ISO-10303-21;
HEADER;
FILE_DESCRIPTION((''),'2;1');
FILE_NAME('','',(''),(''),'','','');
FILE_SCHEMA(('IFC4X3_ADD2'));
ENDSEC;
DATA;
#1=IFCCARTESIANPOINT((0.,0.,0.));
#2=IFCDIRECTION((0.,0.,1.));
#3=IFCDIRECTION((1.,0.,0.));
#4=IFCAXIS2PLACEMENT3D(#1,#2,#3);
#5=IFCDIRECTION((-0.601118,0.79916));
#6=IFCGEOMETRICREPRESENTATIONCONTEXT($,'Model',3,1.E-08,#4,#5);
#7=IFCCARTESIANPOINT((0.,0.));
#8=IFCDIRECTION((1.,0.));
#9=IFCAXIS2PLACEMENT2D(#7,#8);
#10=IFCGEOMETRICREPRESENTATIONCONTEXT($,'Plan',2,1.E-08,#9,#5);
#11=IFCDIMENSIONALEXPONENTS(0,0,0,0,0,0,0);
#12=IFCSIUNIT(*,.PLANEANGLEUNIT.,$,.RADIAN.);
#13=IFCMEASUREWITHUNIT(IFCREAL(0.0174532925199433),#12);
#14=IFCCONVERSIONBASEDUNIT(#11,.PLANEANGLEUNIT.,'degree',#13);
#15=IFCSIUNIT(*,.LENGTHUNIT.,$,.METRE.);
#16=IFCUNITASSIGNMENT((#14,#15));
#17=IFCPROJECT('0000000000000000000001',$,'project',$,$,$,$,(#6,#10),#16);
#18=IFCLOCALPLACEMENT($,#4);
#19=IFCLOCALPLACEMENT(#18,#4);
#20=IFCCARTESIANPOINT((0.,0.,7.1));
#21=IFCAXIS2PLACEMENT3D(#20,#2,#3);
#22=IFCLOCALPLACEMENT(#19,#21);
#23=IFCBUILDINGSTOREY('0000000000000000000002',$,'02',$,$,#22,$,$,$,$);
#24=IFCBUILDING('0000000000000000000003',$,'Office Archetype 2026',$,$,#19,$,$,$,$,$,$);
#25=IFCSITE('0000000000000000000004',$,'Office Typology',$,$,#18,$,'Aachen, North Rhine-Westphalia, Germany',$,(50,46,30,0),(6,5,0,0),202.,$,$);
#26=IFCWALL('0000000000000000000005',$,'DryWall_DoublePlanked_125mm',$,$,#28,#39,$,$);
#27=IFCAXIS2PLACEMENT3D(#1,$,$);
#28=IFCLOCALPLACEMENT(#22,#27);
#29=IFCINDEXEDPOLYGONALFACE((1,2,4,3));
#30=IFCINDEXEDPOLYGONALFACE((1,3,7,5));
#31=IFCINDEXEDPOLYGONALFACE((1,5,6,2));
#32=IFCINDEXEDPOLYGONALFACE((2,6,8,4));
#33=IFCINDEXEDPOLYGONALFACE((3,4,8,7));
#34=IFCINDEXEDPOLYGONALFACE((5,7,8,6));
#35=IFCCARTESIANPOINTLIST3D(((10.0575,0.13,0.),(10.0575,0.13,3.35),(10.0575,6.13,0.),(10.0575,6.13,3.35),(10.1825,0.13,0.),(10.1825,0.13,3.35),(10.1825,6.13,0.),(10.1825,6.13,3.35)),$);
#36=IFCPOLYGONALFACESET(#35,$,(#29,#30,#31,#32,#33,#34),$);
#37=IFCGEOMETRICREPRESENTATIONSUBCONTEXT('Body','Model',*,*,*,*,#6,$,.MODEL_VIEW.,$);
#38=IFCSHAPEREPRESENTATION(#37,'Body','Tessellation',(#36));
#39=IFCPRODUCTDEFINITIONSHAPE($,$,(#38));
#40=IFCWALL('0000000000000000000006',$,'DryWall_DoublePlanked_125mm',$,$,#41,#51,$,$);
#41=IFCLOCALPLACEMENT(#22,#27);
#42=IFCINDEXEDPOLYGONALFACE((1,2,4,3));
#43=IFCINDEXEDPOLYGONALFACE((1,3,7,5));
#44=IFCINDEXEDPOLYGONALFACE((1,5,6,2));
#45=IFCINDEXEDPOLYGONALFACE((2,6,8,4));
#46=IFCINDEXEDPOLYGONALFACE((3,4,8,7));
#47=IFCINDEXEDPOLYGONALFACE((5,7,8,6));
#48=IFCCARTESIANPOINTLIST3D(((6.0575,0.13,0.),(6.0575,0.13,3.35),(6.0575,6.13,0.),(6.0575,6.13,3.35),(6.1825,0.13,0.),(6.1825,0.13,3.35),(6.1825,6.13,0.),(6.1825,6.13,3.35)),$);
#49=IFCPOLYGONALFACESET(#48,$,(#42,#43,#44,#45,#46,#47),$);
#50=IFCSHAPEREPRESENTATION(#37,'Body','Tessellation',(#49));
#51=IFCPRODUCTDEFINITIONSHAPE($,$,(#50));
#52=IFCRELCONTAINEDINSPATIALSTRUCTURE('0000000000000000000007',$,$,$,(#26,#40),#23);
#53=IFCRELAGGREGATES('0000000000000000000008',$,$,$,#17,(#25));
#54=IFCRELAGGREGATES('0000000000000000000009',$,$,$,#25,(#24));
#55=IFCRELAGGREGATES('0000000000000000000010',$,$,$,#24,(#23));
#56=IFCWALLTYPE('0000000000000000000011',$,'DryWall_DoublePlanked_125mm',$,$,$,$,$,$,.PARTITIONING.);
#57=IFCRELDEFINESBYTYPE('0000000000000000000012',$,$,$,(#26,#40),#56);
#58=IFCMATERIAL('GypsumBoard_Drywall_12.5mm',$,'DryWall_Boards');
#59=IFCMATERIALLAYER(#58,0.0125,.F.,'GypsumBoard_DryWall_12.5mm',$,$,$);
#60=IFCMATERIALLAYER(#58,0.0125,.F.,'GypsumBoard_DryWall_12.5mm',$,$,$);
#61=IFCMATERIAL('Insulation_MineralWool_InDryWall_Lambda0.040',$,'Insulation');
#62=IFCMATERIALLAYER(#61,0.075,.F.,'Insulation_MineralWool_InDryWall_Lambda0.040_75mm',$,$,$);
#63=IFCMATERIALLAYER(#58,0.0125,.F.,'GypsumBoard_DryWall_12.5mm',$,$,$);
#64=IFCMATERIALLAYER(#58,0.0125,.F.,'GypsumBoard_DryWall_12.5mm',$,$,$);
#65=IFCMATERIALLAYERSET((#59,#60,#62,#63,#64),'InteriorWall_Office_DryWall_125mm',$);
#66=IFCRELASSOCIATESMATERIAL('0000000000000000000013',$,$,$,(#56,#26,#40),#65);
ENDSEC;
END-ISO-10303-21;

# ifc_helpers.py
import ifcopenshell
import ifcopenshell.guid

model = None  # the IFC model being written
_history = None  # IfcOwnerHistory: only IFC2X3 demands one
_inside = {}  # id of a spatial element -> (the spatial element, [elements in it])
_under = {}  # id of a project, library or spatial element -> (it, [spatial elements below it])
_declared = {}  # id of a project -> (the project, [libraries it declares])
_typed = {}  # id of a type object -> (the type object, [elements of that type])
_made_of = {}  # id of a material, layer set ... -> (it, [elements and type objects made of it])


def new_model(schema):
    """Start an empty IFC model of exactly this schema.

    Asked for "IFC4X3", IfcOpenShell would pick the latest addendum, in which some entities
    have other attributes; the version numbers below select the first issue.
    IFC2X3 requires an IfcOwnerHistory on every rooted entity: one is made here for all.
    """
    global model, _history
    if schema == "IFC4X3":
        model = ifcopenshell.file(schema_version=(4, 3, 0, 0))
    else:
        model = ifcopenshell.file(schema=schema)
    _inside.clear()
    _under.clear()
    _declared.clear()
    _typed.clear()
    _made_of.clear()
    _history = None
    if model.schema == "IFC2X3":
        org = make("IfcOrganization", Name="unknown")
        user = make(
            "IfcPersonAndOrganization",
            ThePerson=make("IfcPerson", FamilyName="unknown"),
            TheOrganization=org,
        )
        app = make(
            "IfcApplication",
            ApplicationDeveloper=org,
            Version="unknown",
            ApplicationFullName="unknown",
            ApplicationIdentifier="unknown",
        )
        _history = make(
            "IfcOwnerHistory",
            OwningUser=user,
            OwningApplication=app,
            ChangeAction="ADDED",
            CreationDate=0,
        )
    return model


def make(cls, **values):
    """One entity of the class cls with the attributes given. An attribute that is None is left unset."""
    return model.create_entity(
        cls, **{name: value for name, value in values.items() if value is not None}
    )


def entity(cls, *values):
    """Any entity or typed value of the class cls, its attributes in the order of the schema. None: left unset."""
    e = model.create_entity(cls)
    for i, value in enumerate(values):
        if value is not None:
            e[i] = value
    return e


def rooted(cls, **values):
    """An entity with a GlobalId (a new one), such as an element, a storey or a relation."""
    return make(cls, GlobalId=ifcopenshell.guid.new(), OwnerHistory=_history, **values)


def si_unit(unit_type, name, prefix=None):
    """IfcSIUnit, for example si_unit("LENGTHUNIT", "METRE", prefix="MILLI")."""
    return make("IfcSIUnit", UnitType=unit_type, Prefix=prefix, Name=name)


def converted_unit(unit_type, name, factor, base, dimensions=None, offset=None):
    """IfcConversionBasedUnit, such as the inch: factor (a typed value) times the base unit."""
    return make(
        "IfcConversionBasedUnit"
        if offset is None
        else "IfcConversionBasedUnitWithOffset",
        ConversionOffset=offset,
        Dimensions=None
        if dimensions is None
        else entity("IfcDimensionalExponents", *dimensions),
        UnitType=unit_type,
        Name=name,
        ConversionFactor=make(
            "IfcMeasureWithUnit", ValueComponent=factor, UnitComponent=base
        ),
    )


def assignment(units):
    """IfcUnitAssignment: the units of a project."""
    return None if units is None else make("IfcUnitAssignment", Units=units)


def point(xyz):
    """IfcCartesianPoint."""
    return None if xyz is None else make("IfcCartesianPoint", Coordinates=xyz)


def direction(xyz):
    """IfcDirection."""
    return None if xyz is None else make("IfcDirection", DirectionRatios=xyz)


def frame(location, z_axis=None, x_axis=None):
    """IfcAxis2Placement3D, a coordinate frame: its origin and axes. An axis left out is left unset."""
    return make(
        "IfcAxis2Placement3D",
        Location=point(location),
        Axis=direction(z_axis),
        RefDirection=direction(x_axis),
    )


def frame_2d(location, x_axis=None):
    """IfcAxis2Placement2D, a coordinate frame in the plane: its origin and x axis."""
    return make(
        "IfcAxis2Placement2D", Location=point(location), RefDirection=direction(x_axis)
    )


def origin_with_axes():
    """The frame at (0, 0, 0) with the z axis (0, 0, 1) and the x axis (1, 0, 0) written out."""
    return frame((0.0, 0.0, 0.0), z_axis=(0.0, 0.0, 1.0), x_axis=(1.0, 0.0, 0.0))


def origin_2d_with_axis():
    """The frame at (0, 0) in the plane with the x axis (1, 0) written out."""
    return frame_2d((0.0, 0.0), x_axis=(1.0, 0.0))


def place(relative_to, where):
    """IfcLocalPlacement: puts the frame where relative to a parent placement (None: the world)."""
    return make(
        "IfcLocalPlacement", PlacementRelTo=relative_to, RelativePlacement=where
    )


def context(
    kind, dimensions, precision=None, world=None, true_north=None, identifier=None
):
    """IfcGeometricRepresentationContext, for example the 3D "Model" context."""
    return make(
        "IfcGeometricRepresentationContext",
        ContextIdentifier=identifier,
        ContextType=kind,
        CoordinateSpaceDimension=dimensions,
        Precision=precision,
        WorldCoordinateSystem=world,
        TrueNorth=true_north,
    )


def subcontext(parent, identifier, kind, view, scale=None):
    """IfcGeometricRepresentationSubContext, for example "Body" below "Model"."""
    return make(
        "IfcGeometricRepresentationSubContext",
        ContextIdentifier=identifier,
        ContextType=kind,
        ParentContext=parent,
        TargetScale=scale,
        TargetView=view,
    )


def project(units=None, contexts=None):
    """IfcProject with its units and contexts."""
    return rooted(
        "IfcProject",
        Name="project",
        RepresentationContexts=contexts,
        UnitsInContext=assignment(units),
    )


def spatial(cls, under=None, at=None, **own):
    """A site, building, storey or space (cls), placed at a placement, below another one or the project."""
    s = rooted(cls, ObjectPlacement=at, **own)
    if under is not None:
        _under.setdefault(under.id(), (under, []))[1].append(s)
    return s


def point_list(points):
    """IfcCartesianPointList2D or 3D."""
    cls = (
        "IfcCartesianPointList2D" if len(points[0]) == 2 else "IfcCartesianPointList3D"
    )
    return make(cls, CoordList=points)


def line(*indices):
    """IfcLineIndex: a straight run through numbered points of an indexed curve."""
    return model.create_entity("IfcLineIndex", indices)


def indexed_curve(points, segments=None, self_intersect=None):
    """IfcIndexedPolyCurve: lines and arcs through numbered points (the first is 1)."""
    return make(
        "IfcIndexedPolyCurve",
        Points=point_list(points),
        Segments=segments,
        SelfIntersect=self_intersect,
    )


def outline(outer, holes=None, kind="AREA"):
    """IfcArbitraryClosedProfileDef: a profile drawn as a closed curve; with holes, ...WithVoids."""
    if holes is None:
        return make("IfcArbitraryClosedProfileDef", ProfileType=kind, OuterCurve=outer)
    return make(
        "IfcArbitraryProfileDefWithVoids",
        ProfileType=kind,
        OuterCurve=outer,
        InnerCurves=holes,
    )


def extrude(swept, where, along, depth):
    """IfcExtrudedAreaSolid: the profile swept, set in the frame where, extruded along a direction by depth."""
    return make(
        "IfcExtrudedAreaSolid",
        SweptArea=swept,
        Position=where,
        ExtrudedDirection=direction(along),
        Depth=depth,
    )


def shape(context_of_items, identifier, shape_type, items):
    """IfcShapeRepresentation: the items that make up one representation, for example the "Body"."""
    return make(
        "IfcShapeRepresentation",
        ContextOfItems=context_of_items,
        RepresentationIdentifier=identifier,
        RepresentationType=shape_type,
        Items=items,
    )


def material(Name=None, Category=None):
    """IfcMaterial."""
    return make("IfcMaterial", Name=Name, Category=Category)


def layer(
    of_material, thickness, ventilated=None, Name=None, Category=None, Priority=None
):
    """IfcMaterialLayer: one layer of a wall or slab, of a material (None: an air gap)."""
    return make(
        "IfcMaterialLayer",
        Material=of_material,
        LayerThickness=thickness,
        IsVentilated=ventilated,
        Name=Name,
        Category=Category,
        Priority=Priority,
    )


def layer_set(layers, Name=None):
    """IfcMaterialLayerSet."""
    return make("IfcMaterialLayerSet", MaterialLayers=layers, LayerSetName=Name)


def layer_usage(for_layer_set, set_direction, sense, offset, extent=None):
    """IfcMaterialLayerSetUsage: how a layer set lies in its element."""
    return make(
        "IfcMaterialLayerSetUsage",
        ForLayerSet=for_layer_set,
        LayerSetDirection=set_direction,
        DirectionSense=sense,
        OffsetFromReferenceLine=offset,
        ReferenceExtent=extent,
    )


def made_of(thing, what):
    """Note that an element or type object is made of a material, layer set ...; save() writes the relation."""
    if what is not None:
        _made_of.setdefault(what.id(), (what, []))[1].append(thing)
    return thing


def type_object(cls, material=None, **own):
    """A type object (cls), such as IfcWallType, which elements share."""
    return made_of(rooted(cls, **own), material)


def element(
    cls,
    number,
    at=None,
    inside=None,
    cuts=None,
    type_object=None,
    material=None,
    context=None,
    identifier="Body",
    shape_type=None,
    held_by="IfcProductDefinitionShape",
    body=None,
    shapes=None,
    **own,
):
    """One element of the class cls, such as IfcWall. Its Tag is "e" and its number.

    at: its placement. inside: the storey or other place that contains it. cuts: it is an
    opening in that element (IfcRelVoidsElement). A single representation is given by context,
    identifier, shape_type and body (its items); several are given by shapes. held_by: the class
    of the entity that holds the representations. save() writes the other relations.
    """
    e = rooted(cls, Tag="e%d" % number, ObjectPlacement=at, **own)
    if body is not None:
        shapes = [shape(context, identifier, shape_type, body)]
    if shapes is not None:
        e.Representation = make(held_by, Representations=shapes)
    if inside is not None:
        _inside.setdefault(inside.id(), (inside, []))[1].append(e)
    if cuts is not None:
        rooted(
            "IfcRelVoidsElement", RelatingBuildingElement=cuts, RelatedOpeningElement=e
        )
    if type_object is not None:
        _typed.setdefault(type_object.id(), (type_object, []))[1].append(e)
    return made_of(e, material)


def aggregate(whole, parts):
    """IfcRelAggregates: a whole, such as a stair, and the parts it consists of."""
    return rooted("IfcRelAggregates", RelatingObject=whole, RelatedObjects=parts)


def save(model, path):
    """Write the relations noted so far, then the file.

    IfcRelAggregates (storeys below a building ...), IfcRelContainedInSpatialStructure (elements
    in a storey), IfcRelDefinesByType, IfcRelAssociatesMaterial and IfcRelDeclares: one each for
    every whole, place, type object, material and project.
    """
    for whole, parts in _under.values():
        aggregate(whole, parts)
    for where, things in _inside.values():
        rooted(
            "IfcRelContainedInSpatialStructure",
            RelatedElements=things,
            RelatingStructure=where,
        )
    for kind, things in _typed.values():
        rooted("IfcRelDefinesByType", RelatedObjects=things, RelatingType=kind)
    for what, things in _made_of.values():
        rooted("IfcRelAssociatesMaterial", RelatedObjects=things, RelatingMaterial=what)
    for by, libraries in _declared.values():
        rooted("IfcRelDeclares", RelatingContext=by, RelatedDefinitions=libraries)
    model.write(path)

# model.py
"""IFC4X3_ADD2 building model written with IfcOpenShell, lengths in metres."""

from ifc_helpers import new_model, entity, si_unit, converted_unit, direction, frame, origin_with_axes, origin_2d_with_axis, place, context, subcontext, project, spatial, line, indexed_curve, outline, extrude, material, layer, layer_set, layer_usage, type_object, element, save


model = new_model("IFC4X3_ADD2")

# Units and contexts
model_context = context("Model", 3, precision=1e-08, world=origin_with_axes(), true_north=direction((-0.601118, 0.79916)))
plan_context = context("Plan", 2, precision=1e-08, world=origin_2d_with_axis(), true_north=direction((-0.601118, 0.79916)))
body_context = subcontext(model_context, "Body", "Model", "MODEL_VIEW")
ifc_project = project(units=[converted_unit("PLANEANGLEUNIT", "degree", entity("IfcReal", 0.0174532925199433), si_unit("PLANEANGLEUNIT", "RADIAN"), dimensions=[0, 0, 0, 0, 0, 0, 0]), si_unit("LENGTHUNIT", "METRE")], contexts=[model_context, plan_context])

# Site, building, storey
site_placement = place(None, origin_with_axes())
site = spatial("IfcSite", under=ifc_project, at=site_placement, Name="Office Typology", LongName="Aachen, North Rhine-Westphalia, Germany", RefLatitude=(50, 46, 30, 0), RefLongitude=(6, 5, 0, 0), RefElevation=202.0)
building_placement = place(site_placement, origin_with_axes())
building = spatial("IfcBuilding", under=site, at=building_placement, Name="Office Archetype 2026")
storey_placement = place(building_placement, frame((0.0, 0.0, 7.1), z_axis=(0.0, 0.0, 1.0), x_axis=(1.0, 0.0, 0.0)))
storey = spatial("IfcBuildingStorey", under=building, at=storey_placement, Name="02")

# Walls
ifc_material_1 = material(Name="GypsumBoard_Drywall_12.5mm", Category="DryWall_Boards")
ifc_layer_1 = layer(ifc_material_1, 0.0125, ventilated=False, Name="GypsumBoard_DryWall_12.5mm")
ifc_layer_2 = layer(ifc_material_1, 0.0125, ventilated=False, Name="GypsumBoard_DryWall_12.5mm")
ifc_material_2 = material(Name="Insulation_MineralWool_InDryWall_Lambda0.040", Category="Insulation")
ifc_layer_3 = layer(ifc_material_2, 0.075, ventilated=False, Name="Insulation_MineralWool_InDryWall_Lambda0.040_75mm")
ifc_layer_4 = layer(ifc_material_1, 0.0125, ventilated=False, Name="GypsumBoard_DryWall_12.5mm")
ifc_layer_5 = layer(ifc_material_1, 0.0125, ventilated=False, Name="GypsumBoard_DryWall_12.5mm")
ifc_layer_set_1 = layer_set([ifc_layer_1, ifc_layer_2, ifc_layer_3, ifc_layer_4, ifc_layer_5], Name="InteriorWall_Office_DryWall_125mm")
ifc_layer_usage_1 = layer_usage(ifc_layer_set_1, "AXIS2", "POSITIVE", 0.0)
wall_type_1 = type_object("IfcWallType", Name="DryWall_DoublePlanked_125mm", PredefinedType="PARTITIONING", material=ifc_layer_set_1)
wall_1_placement = place(storey_placement, frame((10.0575, 6.13, 0.0), z_axis=(0.0, 0.0, 1.0), x_axis=(0.0, -1.0, 0.0)))
element("IfcWall", 1, at=wall_1_placement, inside=storey, type_object=wall_type_1, material=ifc_layer_usage_1, Name="DryWall_DoublePlanked_125mm", context=body_context, shape_type="SweptSolid", body=[
    extrude(outline(indexed_curve([(0.0, 0.0), (0.0, 0.125), (6.0, 0.125), (6.0, 0.0)], segments=[line(1, 2, 3, 4, 1)])), origin_with_axes(), (0.0, 0.0, 1.0), 3.35),
])
ifc_layer_usage_2 = layer_usage(ifc_layer_set_1, "AXIS2", "POSITIVE", 0.0)
wall_2_placement = place(storey_placement, frame((6.0575, 6.13, 0.0), z_axis=(0.0, 0.0, 1.0), x_axis=(0.0, -1.0, 0.0)))
element("IfcWall", 2, at=wall_2_placement, inside=storey, type_object=wall_type_1, material=ifc_layer_usage_2, Name="DryWall_DoublePlanked_125mm", context=body_context, shape_type="SweptSolid", body=[
    extrude(outline(indexed_curve([(0.0, 0.0), (0.0, 0.125), (6.0, 0.125), (6.0, 0.0)], segments=[line(1, 2, 3, 4, 1)])), origin_with_axes(), (0.0, 0.0, 1.0), 3.35),
])

save(model, "model.ifc")
